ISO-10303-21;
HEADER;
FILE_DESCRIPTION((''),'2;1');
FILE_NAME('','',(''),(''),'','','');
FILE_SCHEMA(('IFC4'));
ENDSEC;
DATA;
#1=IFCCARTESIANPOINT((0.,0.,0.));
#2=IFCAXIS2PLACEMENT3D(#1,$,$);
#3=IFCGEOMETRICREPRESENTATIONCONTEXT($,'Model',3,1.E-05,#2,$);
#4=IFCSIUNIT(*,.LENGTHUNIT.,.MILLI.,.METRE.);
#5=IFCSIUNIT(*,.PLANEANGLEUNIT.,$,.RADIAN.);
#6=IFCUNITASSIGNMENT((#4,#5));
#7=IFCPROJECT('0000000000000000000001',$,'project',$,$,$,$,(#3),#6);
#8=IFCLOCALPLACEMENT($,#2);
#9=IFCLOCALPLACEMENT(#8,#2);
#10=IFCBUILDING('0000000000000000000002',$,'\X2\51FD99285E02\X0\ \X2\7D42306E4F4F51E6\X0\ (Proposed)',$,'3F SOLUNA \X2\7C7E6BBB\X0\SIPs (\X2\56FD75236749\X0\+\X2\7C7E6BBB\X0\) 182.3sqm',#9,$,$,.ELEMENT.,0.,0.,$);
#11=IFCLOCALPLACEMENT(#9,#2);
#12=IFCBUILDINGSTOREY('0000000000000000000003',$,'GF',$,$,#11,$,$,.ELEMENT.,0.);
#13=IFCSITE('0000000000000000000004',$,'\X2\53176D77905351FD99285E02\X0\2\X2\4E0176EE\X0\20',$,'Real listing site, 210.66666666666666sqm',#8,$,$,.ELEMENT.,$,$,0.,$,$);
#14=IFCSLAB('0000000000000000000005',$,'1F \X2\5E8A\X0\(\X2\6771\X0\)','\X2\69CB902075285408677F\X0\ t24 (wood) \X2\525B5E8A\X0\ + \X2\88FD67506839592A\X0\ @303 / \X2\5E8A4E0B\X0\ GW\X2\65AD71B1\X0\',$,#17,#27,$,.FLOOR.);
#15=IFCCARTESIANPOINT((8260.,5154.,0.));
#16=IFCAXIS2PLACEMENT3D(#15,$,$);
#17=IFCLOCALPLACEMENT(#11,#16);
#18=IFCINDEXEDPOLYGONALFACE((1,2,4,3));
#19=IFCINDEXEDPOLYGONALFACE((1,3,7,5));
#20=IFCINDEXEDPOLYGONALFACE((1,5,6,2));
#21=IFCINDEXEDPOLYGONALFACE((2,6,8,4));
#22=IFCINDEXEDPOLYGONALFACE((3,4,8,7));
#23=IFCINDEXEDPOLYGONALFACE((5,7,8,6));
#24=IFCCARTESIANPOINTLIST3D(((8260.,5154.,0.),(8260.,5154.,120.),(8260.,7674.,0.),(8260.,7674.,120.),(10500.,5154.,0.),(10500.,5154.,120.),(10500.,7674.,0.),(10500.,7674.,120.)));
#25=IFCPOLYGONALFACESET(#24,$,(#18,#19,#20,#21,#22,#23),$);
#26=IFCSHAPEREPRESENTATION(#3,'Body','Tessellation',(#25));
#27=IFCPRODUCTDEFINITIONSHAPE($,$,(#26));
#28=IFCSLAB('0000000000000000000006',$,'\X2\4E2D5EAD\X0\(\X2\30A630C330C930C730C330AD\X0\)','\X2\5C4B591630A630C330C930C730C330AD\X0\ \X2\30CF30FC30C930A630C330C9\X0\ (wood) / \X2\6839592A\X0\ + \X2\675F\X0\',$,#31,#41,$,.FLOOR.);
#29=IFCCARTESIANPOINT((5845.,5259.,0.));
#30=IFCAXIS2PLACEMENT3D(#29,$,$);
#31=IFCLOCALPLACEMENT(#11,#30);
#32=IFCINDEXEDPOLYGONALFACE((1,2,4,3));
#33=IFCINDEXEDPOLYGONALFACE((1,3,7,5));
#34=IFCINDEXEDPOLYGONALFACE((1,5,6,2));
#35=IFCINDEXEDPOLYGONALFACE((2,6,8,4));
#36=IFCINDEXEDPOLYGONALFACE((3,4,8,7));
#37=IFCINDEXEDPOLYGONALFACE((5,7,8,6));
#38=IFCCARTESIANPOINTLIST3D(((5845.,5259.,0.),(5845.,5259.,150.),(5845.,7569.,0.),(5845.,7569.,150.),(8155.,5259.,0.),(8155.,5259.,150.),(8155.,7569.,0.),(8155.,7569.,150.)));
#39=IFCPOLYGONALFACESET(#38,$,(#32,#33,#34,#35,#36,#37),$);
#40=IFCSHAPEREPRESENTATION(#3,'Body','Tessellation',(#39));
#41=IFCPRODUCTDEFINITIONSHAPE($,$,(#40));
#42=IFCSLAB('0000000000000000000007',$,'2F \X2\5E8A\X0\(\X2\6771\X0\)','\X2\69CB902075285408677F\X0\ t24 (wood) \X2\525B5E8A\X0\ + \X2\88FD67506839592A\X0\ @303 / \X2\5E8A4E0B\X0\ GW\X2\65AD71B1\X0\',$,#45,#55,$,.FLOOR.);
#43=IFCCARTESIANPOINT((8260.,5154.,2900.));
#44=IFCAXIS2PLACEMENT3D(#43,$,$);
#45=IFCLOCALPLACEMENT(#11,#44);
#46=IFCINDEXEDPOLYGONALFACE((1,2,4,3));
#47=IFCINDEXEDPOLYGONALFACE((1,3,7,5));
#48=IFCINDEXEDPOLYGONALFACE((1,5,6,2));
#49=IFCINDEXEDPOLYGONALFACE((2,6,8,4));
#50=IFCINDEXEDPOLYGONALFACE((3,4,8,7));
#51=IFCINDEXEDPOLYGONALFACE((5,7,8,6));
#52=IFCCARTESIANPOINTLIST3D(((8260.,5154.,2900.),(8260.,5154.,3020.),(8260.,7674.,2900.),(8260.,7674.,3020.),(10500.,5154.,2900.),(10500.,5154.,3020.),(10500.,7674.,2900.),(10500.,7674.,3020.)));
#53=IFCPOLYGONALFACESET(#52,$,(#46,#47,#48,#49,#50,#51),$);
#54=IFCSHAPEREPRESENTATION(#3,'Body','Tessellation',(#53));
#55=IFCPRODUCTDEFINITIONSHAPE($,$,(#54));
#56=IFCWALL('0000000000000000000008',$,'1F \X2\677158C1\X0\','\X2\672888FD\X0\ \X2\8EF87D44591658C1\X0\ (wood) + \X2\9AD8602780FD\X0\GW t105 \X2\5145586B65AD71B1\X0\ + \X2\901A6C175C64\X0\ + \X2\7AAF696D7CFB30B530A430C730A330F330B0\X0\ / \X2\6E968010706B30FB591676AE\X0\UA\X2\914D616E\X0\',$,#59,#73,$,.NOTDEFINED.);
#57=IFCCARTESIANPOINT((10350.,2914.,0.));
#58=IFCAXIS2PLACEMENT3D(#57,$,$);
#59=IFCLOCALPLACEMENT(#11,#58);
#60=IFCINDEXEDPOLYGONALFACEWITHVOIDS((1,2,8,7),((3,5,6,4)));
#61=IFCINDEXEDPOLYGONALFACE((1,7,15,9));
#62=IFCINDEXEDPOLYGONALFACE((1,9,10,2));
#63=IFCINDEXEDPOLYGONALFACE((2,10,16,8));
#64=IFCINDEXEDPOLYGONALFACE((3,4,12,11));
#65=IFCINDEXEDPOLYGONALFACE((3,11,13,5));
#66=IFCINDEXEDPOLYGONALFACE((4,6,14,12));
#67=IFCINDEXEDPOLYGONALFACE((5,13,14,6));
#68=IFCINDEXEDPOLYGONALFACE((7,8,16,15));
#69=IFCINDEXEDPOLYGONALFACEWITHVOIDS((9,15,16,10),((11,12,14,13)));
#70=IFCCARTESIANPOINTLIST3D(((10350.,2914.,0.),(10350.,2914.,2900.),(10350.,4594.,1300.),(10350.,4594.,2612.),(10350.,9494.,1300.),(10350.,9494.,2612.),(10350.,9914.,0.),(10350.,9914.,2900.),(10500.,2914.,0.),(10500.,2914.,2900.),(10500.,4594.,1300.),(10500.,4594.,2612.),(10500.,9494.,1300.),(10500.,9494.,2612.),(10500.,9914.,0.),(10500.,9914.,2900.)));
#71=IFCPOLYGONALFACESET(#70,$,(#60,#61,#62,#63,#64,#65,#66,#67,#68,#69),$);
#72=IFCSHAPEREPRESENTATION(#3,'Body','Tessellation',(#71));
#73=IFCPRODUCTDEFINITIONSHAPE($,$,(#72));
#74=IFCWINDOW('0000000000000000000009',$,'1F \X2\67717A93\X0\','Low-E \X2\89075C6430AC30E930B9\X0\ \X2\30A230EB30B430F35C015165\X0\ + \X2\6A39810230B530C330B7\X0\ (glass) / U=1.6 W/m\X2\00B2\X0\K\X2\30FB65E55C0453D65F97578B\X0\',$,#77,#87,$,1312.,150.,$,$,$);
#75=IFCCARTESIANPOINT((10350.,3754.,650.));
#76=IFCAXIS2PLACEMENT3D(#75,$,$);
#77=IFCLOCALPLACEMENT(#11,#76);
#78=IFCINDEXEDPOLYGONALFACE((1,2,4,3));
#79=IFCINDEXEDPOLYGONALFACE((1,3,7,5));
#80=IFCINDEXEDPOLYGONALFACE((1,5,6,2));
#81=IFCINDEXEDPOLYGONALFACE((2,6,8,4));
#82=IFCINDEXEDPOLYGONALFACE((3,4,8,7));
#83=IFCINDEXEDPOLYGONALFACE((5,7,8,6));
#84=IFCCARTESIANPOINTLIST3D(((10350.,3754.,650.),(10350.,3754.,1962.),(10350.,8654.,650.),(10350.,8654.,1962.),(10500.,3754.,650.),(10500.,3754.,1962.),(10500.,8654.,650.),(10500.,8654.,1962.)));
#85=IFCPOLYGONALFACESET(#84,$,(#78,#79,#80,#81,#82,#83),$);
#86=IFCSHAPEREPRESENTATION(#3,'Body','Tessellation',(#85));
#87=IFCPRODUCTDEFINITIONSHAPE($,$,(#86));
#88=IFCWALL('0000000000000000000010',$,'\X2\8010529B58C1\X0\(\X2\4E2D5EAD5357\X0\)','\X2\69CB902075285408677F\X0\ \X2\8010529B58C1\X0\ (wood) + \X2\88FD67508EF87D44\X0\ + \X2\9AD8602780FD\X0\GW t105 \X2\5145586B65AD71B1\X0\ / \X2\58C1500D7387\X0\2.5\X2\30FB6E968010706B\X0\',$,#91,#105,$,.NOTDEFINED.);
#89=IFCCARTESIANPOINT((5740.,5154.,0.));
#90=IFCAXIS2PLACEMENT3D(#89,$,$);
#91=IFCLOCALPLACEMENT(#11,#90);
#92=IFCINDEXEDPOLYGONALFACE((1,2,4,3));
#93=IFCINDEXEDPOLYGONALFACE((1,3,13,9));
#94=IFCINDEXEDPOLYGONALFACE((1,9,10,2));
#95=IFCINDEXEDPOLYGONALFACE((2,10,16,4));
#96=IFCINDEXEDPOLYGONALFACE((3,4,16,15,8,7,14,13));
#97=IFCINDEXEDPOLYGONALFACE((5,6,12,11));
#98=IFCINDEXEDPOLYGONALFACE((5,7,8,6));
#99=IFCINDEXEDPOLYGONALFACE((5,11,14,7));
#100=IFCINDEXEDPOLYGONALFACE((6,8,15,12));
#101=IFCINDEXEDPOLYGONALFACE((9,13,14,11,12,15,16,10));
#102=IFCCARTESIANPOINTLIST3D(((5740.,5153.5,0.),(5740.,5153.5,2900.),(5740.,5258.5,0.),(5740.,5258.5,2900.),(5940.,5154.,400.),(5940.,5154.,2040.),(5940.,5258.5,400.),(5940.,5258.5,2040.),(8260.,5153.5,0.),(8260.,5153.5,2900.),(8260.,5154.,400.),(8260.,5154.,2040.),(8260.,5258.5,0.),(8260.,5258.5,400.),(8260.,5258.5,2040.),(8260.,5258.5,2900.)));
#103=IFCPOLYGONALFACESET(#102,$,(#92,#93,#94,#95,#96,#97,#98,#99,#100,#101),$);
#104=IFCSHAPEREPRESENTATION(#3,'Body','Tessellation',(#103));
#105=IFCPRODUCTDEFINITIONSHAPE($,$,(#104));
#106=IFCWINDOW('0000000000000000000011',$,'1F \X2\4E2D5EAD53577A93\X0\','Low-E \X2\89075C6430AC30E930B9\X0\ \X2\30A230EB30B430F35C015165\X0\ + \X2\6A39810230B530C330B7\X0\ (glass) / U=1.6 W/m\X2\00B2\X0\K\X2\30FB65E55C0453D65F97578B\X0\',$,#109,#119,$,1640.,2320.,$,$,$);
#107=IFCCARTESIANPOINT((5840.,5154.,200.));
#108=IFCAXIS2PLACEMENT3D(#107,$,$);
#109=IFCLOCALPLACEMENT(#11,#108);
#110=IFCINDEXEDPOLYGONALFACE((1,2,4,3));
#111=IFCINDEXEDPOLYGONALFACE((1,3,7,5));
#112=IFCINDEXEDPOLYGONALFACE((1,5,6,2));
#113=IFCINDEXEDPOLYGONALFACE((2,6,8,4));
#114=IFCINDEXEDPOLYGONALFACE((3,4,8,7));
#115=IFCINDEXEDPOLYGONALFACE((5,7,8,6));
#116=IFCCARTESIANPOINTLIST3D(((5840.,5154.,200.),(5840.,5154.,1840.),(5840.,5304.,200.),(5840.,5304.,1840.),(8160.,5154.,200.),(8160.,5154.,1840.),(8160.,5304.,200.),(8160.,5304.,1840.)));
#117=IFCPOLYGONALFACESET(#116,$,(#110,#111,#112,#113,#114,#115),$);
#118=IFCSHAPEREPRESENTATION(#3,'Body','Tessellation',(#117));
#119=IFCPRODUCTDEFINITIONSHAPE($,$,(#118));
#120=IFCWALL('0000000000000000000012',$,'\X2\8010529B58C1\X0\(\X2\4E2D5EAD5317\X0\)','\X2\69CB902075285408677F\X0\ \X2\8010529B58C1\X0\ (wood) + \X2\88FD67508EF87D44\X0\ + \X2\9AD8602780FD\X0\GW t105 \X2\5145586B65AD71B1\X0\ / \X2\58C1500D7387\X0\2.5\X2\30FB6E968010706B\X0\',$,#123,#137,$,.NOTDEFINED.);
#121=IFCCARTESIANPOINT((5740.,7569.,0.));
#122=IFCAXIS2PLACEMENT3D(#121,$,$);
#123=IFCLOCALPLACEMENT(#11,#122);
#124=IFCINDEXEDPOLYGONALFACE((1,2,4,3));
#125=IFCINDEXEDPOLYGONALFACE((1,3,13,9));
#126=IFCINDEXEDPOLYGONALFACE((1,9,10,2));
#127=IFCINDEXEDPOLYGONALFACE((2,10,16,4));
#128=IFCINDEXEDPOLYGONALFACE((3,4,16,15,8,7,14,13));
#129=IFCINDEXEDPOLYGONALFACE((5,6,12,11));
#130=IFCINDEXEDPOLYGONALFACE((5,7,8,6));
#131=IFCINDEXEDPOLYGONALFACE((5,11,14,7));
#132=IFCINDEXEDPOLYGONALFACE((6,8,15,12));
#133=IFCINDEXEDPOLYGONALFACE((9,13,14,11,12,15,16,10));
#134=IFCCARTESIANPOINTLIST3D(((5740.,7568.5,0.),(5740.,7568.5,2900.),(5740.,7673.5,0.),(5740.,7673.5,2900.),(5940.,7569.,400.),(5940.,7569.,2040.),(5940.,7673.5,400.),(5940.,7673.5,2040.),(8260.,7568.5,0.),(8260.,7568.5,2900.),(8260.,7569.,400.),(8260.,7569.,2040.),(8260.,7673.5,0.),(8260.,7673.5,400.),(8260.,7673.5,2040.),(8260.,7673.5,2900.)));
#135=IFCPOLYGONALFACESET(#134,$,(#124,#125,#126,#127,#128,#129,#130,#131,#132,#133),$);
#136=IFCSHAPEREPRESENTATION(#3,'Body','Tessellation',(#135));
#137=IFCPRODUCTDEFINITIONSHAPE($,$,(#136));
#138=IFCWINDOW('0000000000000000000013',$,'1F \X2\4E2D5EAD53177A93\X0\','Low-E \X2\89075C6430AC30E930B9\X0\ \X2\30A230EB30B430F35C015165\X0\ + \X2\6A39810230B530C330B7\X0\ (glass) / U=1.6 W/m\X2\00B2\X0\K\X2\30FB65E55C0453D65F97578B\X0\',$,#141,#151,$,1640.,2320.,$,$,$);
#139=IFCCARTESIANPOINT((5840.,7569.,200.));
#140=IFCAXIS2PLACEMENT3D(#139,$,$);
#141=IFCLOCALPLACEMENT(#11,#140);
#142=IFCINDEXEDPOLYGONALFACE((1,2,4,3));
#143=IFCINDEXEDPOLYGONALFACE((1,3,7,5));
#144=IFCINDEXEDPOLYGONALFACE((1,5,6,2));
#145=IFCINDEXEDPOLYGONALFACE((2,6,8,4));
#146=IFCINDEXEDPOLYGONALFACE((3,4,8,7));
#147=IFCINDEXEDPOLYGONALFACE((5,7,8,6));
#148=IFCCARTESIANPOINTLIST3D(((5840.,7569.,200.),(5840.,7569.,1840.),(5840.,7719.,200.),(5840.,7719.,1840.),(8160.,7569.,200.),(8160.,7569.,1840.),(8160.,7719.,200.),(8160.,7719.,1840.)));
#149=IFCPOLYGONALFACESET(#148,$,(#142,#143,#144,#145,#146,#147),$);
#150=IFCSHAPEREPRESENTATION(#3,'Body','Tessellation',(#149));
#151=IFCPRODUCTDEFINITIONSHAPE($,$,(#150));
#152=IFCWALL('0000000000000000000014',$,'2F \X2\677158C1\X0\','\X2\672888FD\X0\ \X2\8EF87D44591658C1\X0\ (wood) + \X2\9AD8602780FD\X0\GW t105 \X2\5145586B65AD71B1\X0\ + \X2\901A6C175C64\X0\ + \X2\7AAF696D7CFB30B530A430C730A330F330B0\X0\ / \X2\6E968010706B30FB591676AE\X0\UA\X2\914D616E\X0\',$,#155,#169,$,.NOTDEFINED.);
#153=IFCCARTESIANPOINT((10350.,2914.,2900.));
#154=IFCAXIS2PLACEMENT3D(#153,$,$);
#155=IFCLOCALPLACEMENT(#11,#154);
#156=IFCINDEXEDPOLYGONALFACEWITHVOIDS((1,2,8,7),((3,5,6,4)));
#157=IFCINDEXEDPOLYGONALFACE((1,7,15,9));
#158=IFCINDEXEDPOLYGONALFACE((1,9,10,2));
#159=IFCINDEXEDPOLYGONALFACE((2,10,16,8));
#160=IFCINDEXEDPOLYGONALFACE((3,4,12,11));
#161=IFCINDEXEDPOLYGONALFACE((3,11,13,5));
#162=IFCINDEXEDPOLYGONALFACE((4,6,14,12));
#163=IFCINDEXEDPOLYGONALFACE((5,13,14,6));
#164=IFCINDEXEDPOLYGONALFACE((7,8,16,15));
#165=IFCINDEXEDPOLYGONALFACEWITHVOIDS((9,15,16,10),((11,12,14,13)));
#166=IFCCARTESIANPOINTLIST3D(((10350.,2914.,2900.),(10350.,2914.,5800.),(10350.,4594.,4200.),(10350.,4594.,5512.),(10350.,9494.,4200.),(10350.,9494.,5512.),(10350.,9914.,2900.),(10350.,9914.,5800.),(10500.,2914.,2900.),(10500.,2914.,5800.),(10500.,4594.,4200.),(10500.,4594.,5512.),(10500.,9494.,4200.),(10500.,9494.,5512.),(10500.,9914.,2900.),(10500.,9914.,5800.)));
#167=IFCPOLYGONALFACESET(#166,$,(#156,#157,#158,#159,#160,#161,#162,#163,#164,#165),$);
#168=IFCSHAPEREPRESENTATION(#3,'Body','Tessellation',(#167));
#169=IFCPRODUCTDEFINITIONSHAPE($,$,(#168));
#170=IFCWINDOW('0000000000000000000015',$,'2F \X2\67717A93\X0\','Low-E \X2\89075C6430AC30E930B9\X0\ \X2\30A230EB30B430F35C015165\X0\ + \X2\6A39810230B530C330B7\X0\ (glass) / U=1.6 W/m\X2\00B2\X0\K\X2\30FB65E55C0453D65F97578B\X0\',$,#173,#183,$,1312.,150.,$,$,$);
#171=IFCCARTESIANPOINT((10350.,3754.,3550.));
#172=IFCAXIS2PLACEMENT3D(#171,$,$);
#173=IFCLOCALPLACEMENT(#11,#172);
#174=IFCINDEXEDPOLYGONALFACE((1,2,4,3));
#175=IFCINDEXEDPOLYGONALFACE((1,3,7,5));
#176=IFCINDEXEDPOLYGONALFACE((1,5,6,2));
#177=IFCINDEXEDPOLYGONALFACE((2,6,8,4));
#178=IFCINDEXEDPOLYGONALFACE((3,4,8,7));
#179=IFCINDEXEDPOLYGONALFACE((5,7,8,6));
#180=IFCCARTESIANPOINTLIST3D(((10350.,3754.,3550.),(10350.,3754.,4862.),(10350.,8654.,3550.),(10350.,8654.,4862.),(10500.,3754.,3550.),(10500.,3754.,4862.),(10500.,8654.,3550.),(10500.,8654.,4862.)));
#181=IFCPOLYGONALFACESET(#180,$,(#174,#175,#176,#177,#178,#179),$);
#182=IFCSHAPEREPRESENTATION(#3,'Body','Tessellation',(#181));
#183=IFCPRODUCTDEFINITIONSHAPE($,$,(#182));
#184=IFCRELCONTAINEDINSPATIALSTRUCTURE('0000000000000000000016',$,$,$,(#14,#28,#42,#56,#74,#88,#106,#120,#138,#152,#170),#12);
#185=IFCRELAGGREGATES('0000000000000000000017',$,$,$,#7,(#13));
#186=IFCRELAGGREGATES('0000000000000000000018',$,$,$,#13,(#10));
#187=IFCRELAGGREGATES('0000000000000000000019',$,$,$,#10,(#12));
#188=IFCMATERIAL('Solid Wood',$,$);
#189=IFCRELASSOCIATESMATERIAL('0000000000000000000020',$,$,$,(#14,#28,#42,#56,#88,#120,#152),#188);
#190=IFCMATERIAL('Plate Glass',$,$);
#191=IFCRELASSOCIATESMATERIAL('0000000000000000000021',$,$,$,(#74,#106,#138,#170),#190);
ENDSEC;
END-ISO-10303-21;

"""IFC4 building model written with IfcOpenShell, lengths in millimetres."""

from ifc_helpers import new_model, si_unit, frame, frame_2d, origin, place, context, project, spatial, rectangle, extrude, material, element, fill, save


model = new_model("IFC4")

# Units and contexts
model_context = context("Model", 3, precision=1e-05, world=origin())
ifc_project = project(units=[si_unit("LENGTHUNIT", "METRE", prefix="MILLI"), si_unit("PLANEANGLEUNIT", "RADIAN")], contexts=[model_context])

# Site, building, storey
site_placement = place(None, origin())
site = spatial("IfcSite", under=ifc_project, at=site_placement, Name="北海道函館市2丁目20", ObjectType="Real listing site, 210.66666666666666sqm", CompositionType="ELEMENT", RefElevation=0.0)
building_placement = place(site_placement, origin())
building = spatial("IfcBuilding", under=site, at=building_placement, Name="函館市 終の住処 (Proposed)", ObjectType="3F SOLUNA 籾殻SIPs (国産杉+籾殻) 182.3sqm", CompositionType="ELEMENT", ElevationOfRefHeight=0.0, ElevationOfTerrain=0.0)
storey_placement = place(building_placement, origin())
storey = spatial("IfcBuildingStorey", under=building, at=storey_placement, Name="GF", CompositionType="ELEMENT", Elevation=0.0)

# Slabs
ifc_material_1 = material(Name="Solid Wood")
slab_1_placement = place(storey_placement, frame((8260.0, 5154.0, 0.0)))
element("IfcSlab", 1, at=slab_1_placement, inside=storey, material=ifc_material_1, Name="1F 床(東)", Description="構造用合板 t24 (wood) 剛床 + 製材根太 @303 / 床下 GW断熱", PredefinedType="FLOOR", context=model_context, shape_type="SweptSolid", body=[
    extrude(rectangle(XDim=2240.0, YDim=2520.0, at=frame_2d((1120.0, 1260.0))), frame((8260.0, 5154.0, 0.0)), (0.0, 0.0, 1.0), 120.0),
])
slab_2_placement = place(storey_placement, frame((5845.0, 5259.0, 0.0)))
element("IfcSlab", 2, at=slab_2_placement, inside=storey, material=ifc_material_1, Name="中庭(ウッドデッキ)", Description="屋外ウッドデッキ ハードウッド (wood) / 根太 + 束", PredefinedType="FLOOR", context=model_context, shape_type="SweptSolid", body=[
    extrude(rectangle(XDim=2310.0, YDim=2310.0, at=frame_2d((1155.0, 1155.0))), frame((5845.0, 5259.0, 0.0)), (0.0, 0.0, 1.0), 150.0),
])
slab_3_placement = place(storey_placement, frame((8260.0, 5154.0, 2900.0)))
element("IfcSlab", 3, at=slab_3_placement, inside=storey, material=ifc_material_1, Name="2F 床(東)", Description="構造用合板 t24 (wood) 剛床 + 製材根太 @303 / 床下 GW断熱", PredefinedType="FLOOR", context=model_context, shape_type="SweptSolid", body=[
    extrude(rectangle(XDim=2240.0, YDim=2520.0, at=frame_2d((1120.0, 1260.0))), frame((8260.0, 5154.0, 2900.0)), (0.0, 0.0, 1.0), 120.0),
])

# Walls, openings, windows
wall_1_placement = place(storey_placement, frame((10350.0, 2914.0, 0.0)))
wall_1 = element("IfcWall", 4, at=wall_1_placement, inside=storey, material=ifc_material_1, Name="1F 東壁", Description="木製 軸組外壁 (wood) + 高性能GW t105 充填断熱 + 通気層 + 窯業系サイディング / 準耐火・外皮UA配慮", PredefinedType="NOTDEFINED", context=model_context, shape_type="SweptSolid", body=[
    extrude(rectangle(XDim=150.0, YDim=7000.0, at=frame_2d((75.0, 3500.0))), frame((10350.0, 2914.0, 0.0)), (0.0, 0.0, 1.0), 2900.0),
])
opening_1_placement = place(storey_placement, frame((10350.0, 3754.0, 650.0)))
opening_1 = element("IfcOpeningElement", 5, at=opening_1_placement, cuts=wall_1, PredefinedType="NOTDEFINED", context=model_context, shape_type="SweptSolid", body=[
    extrude(rectangle(XDim=150.0, YDim=4900.0, at=frame_2d((75.0, 2450.0))), frame((10350.0, 3754.0, 650.0)), (0.0, 0.0, 1.0), 1312.0),
])
ifc_material_2 = material(Name="Plate Glass")
window_1_placement = place(storey_placement, frame((10350.0, 3754.0, 650.0)))
window_1 = element("IfcWindow", 6, at=window_1_placement, inside=storey, material=ifc_material_2, Name="1F 東窓", Description="Low-E 複層ガラス アルゴン封入 + 樹脂サッシ (glass) / U=1.6 W/m²K・日射取得型", OverallHeight=1312.0, OverallWidth=150.0, context=model_context, shape_type="SweptSolid", body=[
    extrude(rectangle(XDim=150.0, YDim=4900.0, at=frame_2d((75.0, 2450.0))), frame((10350.0, 3754.0, 650.0)), (0.0, 0.0, 1.0), 1312.0),
])
fill(opening_1, window_1)
wall_2_placement = place(storey_placement, frame((5740.0, 5154.0, 0.0)))
wall_2 = element("IfcWall", 7, at=wall_2_placement, inside=storey, material=ifc_material_1, Name="耐力壁(中庭南)", Description="構造用合板 耐力壁 (wood) + 製材軸組 + 高性能GW t105 充填断熱 / 壁倍率2.5・準耐火", PredefinedType="NOTDEFINED", context=model_context, shape_type="SweptSolid", body=[
    extrude(rectangle(XDim=2520.0, YDim=105.0, at=frame_2d((1260.0, 52.0))), frame((5740.0, 5154.0, 0.0)), (0.0, 0.0, 1.0), 2900.0),
])
opening_2_placement = place(storey_placement, frame((5840.0, 5154.0, 200.0)))
opening_2 = element("IfcOpeningElement", 8, at=opening_2_placement, cuts=wall_2, PredefinedType="NOTDEFINED", context=model_context, shape_type="SweptSolid", body=[
    extrude(rectangle(XDim=2320.0, YDim=150.0, at=frame_2d((1160.0, 75.0))), frame((5840.0, 5154.0, 200.0)), (0.0, 0.0, 1.0), 1640.0),
])
window_2_placement = place(storey_placement, frame((5840.0, 5154.0, 200.0)))
window_2 = element("IfcWindow", 9, at=window_2_placement, inside=storey, material=ifc_material_2, Name="1F 中庭南窓", Description="Low-E 複層ガラス アルゴン封入 + 樹脂サッシ (glass) / U=1.6 W/m²K・日射取得型", OverallHeight=1640.0, OverallWidth=2320.0, context=model_context, shape_type="SweptSolid", body=[
    extrude(rectangle(XDim=2320.0, YDim=150.0, at=frame_2d((1160.0, 75.0))), frame((5840.0, 5154.0, 200.0)), (0.0, 0.0, 1.0), 1640.0),
])
fill(opening_2, window_2)
wall_3_placement = place(storey_placement, frame((5740.0, 7569.0, 0.0)))
wall_3 = element("IfcWall", 10, at=wall_3_placement, inside=storey, material=ifc_material_1, Name="耐力壁(中庭北)", Description="構造用合板 耐力壁 (wood) + 製材軸組 + 高性能GW t105 充填断熱 / 壁倍率2.5・準耐火", PredefinedType="NOTDEFINED", context=model_context, shape_type="SweptSolid", body=[
    extrude(rectangle(XDim=2520.0, YDim=105.0, at=frame_2d((1260.0, 52.0))), frame((5740.0, 7569.0, 0.0)), (0.0, 0.0, 1.0), 2900.0),
])
opening_3_placement = place(storey_placement, frame((5840.0, 7569.0, 200.0)))
opening_3 = element("IfcOpeningElement", 11, at=opening_3_placement, cuts=wall_3, PredefinedType="NOTDEFINED", context=model_context, shape_type="SweptSolid", body=[
    extrude(rectangle(XDim=2320.0, YDim=150.0, at=frame_2d((1160.0, 75.0))), frame((5840.0, 7569.0, 200.0)), (0.0, 0.0, 1.0), 1640.0),
])
window_3_placement = place(storey_placement, frame((5840.0, 7569.0, 200.0)))
window_3 = element("IfcWindow", 12, at=window_3_placement, inside=storey, material=ifc_material_2, Name="1F 中庭北窓", Description="Low-E 複層ガラス アルゴン封入 + 樹脂サッシ (glass) / U=1.6 W/m²K・日射取得型", OverallHeight=1640.0, OverallWidth=2320.0, context=model_context, shape_type="SweptSolid", body=[
    extrude(rectangle(XDim=2320.0, YDim=150.0, at=frame_2d((1160.0, 75.0))), frame((5840.0, 7569.0, 200.0)), (0.0, 0.0, 1.0), 1640.0),
])
fill(opening_3, window_3)

# Wall, opening, window
wall_4_placement = place(storey_placement, frame((10350.0, 2914.0, 2900.0)))
wall_4 = element("IfcWall", 13, at=wall_4_placement, inside=storey, material=ifc_material_1, Name="2F 東壁", Description="木製 軸組外壁 (wood) + 高性能GW t105 充填断熱 + 通気層 + 窯業系サイディング / 準耐火・外皮UA配慮", PredefinedType="NOTDEFINED", context=model_context, shape_type="SweptSolid", body=[
    extrude(rectangle(XDim=150.0, YDim=7000.0, at=frame_2d((75.0, 3500.0))), frame((10350.0, 2914.0, 2900.0)), (0.0, 0.0, 1.0), 2900.0),
])
opening_4_placement = place(storey_placement, frame((10350.0, 3754.0, 3550.0)))
opening_4 = element("IfcOpeningElement", 14, at=opening_4_placement, cuts=wall_4, PredefinedType="NOTDEFINED", context=model_context, shape_type="SweptSolid", body=[
    extrude(rectangle(XDim=150.0, YDim=4900.0, at=frame_2d((75.0, 2450.0))), frame((10350.0, 3754.0, 3550.0)), (0.0, 0.0, 1.0), 1312.0),
])
window_4_placement = place(storey_placement, frame((10350.0, 3754.0, 3550.0)))
window_4 = element("IfcWindow", 15, at=window_4_placement, inside=storey, material=ifc_material_2, Name="2F 東窓", Description="Low-E 複層ガラス アルゴン封入 + 樹脂サッシ (glass) / U=1.6 W/m²K・日射取得型", OverallHeight=1312.0, OverallWidth=150.0, context=model_context, shape_type="SweptSolid", body=[
    extrude(rectangle(XDim=150.0, YDim=4900.0, at=frame_2d((75.0, 2450.0))), frame((10350.0, 3754.0, 3550.0)), (0.0, 0.0, 1.0), 1312.0),
])
fill(opening_4, window_4)

save(model, "model.ifc")
